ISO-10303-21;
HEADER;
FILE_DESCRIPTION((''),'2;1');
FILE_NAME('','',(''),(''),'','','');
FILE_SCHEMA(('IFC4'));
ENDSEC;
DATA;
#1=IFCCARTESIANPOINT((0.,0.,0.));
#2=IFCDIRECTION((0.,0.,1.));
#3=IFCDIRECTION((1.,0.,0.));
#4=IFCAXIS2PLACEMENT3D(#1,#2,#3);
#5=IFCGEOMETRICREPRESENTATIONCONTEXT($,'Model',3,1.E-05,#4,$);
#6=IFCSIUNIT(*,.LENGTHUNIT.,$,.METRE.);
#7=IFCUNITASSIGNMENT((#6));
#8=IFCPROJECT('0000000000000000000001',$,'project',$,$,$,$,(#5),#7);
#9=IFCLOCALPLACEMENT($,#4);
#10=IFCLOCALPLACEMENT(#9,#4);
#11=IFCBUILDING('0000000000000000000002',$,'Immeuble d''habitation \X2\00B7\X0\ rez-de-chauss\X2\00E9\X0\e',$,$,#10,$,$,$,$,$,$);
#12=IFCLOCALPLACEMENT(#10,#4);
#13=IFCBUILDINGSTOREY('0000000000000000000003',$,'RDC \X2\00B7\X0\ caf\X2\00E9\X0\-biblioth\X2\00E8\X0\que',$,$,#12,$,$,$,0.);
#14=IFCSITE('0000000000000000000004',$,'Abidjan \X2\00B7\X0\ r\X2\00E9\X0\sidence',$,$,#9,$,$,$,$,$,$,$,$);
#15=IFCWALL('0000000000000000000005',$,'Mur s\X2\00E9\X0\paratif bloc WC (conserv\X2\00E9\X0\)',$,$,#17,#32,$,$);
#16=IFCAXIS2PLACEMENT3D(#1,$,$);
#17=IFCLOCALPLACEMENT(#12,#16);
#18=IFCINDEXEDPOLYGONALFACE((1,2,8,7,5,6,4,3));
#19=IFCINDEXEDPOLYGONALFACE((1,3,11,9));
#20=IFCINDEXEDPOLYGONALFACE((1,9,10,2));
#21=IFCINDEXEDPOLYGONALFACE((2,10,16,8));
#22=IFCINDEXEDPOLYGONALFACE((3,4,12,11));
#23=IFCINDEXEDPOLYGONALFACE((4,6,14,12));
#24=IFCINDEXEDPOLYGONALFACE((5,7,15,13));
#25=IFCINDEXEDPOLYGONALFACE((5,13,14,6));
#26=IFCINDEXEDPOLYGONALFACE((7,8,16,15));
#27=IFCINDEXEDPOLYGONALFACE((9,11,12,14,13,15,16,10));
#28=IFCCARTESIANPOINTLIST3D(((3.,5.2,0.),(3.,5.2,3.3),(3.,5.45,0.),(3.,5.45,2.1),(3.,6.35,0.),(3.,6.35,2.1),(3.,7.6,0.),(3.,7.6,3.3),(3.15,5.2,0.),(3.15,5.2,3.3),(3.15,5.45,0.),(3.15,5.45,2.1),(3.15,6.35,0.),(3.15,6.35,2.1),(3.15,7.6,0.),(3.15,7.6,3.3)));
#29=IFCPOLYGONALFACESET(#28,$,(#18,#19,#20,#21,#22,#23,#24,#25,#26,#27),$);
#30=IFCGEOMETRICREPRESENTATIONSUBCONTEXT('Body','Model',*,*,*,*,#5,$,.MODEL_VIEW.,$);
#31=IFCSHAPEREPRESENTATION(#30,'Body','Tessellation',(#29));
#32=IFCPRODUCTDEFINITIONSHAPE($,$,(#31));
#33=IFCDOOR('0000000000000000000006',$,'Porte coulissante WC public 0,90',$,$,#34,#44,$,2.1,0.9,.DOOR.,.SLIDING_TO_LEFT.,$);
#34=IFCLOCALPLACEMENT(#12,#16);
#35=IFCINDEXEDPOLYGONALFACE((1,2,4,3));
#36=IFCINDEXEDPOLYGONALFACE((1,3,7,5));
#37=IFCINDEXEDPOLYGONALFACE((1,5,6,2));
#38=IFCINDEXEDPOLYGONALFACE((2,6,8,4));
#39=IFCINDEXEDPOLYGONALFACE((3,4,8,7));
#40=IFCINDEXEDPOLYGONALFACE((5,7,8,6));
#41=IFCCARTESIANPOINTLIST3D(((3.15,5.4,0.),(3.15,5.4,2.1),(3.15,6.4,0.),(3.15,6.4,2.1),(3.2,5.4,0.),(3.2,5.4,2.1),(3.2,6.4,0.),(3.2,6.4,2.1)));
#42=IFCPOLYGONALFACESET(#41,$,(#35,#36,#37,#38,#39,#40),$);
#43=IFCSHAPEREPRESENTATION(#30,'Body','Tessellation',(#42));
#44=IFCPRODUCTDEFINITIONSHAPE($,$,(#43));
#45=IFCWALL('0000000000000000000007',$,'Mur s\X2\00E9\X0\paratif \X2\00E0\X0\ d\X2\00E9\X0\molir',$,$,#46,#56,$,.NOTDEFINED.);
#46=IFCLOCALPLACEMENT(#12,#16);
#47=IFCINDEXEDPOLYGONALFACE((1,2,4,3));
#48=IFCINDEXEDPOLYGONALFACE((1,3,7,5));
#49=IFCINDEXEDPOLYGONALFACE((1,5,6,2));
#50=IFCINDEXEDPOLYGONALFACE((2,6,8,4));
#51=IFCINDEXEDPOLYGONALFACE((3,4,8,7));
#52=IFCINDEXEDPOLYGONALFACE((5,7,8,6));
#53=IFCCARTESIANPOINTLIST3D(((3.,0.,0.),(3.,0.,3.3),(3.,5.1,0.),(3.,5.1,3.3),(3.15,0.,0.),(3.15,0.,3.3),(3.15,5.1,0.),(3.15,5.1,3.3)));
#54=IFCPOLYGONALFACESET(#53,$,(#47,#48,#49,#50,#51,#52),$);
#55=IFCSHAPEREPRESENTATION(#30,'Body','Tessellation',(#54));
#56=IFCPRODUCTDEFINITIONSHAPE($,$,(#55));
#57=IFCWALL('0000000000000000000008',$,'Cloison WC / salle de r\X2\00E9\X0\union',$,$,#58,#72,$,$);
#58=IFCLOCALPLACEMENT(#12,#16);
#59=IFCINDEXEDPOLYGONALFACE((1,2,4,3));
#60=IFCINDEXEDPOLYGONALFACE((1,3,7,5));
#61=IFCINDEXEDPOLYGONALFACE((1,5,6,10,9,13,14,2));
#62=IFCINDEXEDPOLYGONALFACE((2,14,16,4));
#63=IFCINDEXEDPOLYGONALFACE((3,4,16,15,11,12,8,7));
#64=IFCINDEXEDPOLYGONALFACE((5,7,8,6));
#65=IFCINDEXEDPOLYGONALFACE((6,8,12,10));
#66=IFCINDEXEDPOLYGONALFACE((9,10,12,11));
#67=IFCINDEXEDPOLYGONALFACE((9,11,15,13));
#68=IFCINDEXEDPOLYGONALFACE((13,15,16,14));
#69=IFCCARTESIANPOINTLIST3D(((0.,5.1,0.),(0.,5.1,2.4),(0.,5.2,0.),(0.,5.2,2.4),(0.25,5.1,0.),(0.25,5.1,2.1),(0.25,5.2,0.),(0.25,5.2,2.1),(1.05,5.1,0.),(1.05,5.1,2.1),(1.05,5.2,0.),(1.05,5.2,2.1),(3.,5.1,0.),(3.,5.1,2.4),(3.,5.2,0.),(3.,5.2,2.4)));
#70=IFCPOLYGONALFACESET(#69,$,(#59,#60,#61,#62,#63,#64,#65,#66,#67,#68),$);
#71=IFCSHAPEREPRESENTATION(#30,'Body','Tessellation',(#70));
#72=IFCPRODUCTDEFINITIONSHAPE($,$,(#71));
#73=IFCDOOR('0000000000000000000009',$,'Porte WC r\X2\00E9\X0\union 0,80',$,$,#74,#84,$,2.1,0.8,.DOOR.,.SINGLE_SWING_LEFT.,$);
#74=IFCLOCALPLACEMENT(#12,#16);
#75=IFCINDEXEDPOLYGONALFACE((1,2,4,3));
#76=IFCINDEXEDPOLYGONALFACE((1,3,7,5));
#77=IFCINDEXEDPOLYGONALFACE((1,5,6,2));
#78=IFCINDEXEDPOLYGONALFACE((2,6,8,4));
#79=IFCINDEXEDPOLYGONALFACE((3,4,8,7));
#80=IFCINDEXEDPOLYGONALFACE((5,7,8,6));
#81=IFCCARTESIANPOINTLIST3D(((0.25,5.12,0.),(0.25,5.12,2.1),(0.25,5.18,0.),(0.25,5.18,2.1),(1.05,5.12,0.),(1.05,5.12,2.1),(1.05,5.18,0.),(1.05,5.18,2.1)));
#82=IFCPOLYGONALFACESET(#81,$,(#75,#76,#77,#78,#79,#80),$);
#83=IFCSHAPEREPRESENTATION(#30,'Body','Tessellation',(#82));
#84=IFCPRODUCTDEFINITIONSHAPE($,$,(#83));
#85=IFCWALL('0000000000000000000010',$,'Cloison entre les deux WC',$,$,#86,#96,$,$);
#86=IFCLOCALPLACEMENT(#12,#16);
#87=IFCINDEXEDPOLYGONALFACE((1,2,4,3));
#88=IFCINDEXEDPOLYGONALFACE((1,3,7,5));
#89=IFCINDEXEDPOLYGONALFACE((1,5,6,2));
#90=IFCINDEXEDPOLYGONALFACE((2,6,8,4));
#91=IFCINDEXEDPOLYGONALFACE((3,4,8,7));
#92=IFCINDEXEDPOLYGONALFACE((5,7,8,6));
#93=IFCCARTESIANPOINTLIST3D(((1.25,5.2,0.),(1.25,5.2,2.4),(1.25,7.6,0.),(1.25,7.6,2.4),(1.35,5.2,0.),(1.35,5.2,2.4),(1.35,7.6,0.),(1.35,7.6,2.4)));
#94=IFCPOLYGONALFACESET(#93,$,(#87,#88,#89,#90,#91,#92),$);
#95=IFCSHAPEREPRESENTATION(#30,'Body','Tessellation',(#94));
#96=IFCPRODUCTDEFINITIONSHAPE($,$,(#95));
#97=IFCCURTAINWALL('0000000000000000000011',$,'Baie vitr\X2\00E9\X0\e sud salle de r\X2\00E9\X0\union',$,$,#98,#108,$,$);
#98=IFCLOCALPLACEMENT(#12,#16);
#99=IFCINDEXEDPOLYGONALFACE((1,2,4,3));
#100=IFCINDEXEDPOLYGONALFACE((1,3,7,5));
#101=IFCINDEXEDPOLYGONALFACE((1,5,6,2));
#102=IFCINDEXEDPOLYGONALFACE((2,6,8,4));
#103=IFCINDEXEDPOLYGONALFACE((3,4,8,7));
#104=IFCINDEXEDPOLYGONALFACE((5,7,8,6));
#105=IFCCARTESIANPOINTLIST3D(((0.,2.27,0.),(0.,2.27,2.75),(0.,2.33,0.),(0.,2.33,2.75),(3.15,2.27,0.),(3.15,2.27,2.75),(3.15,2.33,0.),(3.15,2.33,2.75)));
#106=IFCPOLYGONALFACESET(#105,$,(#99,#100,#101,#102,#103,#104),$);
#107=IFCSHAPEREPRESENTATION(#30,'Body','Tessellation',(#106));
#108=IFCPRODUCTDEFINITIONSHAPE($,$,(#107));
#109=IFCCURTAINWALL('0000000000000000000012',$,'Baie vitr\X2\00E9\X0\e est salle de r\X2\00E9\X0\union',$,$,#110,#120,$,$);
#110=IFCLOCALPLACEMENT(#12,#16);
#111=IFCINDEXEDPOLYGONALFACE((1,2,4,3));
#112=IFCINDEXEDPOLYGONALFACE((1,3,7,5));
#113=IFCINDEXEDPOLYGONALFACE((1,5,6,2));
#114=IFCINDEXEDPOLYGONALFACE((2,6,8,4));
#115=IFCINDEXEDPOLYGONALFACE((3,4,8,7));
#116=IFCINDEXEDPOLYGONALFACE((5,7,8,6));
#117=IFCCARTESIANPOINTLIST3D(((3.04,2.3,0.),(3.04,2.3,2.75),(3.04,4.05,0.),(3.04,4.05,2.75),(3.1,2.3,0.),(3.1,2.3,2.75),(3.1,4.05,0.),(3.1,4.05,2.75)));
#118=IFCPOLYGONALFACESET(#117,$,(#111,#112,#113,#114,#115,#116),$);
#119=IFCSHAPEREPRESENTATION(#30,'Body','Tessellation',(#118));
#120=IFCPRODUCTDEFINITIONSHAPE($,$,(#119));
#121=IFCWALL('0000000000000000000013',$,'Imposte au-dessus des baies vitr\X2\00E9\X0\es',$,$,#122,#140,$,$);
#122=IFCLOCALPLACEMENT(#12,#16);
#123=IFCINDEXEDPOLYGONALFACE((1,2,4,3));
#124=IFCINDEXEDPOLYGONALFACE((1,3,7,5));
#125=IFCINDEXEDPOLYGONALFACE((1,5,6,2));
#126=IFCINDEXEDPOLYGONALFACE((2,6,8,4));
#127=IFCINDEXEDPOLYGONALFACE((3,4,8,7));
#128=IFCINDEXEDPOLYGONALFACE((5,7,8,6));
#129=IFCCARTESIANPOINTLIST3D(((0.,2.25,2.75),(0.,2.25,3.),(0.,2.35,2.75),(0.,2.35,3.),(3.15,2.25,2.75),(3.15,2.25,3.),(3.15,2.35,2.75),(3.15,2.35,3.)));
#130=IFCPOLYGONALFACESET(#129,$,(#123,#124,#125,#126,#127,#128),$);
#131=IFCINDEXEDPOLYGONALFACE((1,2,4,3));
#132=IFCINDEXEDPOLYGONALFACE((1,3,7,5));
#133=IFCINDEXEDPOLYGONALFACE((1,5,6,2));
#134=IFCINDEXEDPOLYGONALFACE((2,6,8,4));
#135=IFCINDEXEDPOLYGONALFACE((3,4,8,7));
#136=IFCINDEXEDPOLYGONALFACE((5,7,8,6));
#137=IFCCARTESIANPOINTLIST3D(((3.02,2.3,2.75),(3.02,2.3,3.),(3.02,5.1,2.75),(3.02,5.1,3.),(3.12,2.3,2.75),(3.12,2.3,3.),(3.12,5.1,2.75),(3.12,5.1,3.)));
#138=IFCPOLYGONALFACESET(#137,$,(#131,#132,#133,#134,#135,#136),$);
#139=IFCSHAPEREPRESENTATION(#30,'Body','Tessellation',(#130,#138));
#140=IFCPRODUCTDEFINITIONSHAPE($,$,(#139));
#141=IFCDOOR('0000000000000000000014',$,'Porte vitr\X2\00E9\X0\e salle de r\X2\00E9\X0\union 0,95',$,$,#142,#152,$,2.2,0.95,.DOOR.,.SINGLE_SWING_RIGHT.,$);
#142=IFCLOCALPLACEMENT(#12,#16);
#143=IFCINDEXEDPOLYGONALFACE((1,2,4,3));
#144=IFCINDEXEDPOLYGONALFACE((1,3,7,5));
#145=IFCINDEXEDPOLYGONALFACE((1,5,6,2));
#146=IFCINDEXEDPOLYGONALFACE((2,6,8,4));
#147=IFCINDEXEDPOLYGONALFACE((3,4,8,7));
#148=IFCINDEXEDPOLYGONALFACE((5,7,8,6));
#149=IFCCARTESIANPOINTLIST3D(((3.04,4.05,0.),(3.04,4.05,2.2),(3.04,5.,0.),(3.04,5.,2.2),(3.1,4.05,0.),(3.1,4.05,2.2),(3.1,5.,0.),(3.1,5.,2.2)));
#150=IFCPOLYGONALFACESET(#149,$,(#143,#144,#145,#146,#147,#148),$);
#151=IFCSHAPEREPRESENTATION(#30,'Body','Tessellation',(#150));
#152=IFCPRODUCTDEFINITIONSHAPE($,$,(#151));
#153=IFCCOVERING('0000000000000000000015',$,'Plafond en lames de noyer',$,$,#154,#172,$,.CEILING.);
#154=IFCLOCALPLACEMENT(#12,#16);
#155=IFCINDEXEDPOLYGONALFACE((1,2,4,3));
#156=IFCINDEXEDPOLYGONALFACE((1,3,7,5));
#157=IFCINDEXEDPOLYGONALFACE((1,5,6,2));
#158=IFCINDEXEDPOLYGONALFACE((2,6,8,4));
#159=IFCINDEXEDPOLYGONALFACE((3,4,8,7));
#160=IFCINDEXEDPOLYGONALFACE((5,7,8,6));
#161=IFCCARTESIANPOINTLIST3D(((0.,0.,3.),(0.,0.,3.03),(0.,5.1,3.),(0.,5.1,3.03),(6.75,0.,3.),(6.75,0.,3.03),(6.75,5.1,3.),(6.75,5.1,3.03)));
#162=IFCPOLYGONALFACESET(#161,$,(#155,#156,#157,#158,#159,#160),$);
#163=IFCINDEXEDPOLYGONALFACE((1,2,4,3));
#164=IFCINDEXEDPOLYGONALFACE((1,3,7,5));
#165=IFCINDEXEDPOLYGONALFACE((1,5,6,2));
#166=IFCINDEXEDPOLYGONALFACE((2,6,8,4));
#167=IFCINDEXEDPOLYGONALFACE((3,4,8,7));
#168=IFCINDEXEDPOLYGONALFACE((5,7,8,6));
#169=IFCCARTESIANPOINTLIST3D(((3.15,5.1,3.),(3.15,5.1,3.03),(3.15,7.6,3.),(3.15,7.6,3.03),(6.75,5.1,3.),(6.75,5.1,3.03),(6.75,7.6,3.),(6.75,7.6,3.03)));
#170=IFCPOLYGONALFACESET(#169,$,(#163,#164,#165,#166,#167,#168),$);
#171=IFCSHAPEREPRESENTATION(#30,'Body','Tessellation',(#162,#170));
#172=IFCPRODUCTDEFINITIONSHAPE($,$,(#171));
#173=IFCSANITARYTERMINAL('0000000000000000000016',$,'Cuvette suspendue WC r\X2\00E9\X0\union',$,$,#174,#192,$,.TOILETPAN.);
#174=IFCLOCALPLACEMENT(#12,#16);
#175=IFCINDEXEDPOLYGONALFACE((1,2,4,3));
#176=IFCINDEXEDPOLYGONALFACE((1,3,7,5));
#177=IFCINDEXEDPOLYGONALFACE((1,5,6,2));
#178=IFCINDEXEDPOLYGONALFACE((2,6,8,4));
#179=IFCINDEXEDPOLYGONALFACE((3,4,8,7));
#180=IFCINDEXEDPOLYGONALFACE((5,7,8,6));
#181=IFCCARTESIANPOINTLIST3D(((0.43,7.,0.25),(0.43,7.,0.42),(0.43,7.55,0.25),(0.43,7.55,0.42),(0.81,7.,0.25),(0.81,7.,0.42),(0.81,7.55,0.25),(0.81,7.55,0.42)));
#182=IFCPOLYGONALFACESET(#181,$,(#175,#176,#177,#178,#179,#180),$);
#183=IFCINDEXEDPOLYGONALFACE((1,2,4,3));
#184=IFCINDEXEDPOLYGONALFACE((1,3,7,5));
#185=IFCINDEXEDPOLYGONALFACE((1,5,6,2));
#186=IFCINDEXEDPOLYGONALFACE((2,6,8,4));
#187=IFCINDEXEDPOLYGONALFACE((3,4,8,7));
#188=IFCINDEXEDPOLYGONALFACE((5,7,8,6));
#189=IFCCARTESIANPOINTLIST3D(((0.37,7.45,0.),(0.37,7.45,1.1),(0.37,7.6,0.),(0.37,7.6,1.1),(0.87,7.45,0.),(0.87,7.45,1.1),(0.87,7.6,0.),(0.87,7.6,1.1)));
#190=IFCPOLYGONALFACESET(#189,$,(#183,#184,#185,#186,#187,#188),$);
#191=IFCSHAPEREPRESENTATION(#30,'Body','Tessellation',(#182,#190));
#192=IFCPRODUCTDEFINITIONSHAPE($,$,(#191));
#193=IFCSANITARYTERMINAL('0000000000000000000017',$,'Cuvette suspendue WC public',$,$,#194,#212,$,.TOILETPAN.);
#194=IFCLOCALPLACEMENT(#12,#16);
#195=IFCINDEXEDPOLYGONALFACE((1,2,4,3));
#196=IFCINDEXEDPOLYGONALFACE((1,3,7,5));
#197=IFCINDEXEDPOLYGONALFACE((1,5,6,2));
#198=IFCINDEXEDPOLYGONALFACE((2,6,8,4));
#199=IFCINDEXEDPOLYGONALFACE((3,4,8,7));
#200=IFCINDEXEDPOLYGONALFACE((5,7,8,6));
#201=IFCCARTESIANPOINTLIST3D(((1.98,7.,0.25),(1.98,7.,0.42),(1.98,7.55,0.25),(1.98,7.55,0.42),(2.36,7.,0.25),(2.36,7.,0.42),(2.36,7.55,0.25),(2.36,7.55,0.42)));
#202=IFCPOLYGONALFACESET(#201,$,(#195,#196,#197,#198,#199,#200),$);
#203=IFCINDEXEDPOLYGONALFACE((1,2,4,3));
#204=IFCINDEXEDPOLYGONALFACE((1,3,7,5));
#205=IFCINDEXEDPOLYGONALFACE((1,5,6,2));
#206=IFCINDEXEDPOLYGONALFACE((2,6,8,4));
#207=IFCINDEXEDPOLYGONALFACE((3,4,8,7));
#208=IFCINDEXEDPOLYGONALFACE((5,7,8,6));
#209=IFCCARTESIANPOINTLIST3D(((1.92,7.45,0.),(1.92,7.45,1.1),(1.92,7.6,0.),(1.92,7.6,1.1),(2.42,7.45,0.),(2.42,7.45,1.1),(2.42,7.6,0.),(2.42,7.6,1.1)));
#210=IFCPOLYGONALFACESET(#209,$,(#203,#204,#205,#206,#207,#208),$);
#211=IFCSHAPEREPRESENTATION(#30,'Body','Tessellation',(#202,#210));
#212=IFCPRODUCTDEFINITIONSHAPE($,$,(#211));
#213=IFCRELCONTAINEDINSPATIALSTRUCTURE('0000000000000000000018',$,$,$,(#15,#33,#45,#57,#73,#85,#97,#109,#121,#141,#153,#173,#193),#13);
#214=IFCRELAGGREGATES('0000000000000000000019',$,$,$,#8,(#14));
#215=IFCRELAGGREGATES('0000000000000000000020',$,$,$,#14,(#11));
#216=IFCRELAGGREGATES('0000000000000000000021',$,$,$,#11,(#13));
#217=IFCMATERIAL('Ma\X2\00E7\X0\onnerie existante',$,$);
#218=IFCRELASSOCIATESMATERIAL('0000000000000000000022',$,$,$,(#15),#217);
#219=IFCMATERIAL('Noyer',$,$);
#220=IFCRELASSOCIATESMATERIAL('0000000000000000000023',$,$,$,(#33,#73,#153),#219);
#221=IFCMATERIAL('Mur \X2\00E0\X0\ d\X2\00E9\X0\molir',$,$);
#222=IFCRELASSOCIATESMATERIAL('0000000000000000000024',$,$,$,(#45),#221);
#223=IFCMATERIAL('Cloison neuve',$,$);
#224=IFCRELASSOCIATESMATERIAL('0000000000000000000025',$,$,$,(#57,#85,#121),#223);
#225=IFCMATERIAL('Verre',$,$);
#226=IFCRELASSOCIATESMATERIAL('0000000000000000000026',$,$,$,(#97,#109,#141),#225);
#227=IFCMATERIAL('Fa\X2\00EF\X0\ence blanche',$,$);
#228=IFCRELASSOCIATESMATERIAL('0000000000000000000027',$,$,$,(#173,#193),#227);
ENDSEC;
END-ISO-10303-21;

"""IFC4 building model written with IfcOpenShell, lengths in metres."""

from ifc_helpers import new_model, si_unit, frame, frame_2d, origin, origin_with_axes, place, context, subcontext, project, spatial, rectangle, extrude, material, element, fill, save


model = new_model("IFC4")

# Units and contexts
model_context = context("Model", 3, precision=1e-05, world=origin_with_axes())
body_context = subcontext(model_context, "Body", "Model", "MODEL_VIEW")
ifc_project = project(units=[si_unit("LENGTHUNIT", "METRE")], contexts=[model_context])

# Site, building, storey
site_placement = place(None, origin_with_axes())
site = spatial("IfcSite", under=ifc_project, at=site_placement, Name="Abidjan · résidence")
building_placement = place(site_placement, origin_with_axes())
building = spatial("IfcBuilding", under=site, at=building_placement, Name="Immeuble d'habitation · rez-de-chaussée")
storey_placement = place(building_placement, origin_with_axes())
storey = spatial("IfcBuildingStorey", under=building, at=storey_placement, Name="RDC · café-bibliothèque", Elevation=0.0)

# Shared definitions
ifc_material_1 = material(Name="Cloison neuve")

# Shared definitions
ifc_material_2 = material(Name="Maçonnerie existante")

# Shared definitions
ifc_material_3 = material(Name="Verre")

# Wall, opening, door
wall_1_placement = place(storey_placement, origin_with_axes())
wall_1 = element("IfcWall", 1, at=wall_1_placement, inside=storey, material=ifc_material_2, Name="Mur séparatif bloc WC (conservé)", context=body_context, shape_type="SweptSolid", body=[
    extrude(rectangle(XDim=0.15, YDim=2.4, at=frame_2d((3.075, 6.4))), origin(), (0.0, 0.0, 1.0), 3.3),
])
opening_1_placement = place(wall_1_placement, origin_with_axes())
opening_1 = element("IfcOpeningElement", 2, at=opening_1_placement, cuts=wall_1, context=body_context, shape_type="SweptSolid", body=[
    extrude(rectangle(XDim=0.25, YDim=0.9, at=frame_2d((3.075, 5.9))), origin(), (0.0, 0.0, 1.0), 2.1),
])
ifc_material_4 = material(Name="Noyer")
door_1_placement = place(storey_placement, origin_with_axes())
door_1 = element("IfcDoor", 3, at=door_1_placement, inside=storey, material=ifc_material_4, Name="Porte coulissante WC public 0,90", OperationType="SLIDING_TO_LEFT", OverallHeight=2.1, OverallWidth=0.9, PredefinedType="DOOR", context=body_context, shape_type="SweptSolid", body=[
    extrude(rectangle(XDim=0.05, YDim=1.0, at=frame_2d((3.175, 5.9))), origin(), (0.0, 0.0, 1.0), 2.1),
])
fill(opening_1, door_1)

# Wall
ifc_material_5 = material(Name="Mur à démolir")
wall_2_placement = place(storey_placement, origin_with_axes())
element("IfcWall", 4, at=wall_2_placement, inside=storey, material=ifc_material_5, Name="Mur séparatif à démolir", PredefinedType="NOTDEFINED", context=body_context, shape_type="SweptSolid", body=[
    extrude(rectangle(XDim=0.15, YDim=5.1, at=frame_2d((3.075, 2.55))), origin(), (0.0, 0.0, 1.0), 3.3),
])

# Wall, opening, door
wall_3_placement = place(storey_placement, origin_with_axes())
wall_3 = element("IfcWall", 5, at=wall_3_placement, inside=storey, material=ifc_material_1, Name="Cloison WC / salle de réunion", context=body_context, shape_type="SweptSolid", body=[
    extrude(rectangle(XDim=3.0, YDim=0.1, at=frame_2d((1.5, 5.15))), origin(), (0.0, 0.0, 1.0), 2.4),
])
opening_2_placement = place(wall_3_placement, origin_with_axes())
opening_2 = element("IfcOpeningElement", 6, at=opening_2_placement, cuts=wall_3, context=body_context, shape_type="SweptSolid", body=[
    extrude(rectangle(XDim=0.8, YDim=0.2, at=frame_2d((0.65, 5.15))), origin(), (0.0, 0.0, 1.0), 2.1),
])
door_2_placement = place(storey_placement, origin_with_axes())
door_2 = element("IfcDoor", 7, at=door_2_placement, inside=storey, material=ifc_material_4, Name="Porte WC réunion 0,80", OperationType="SINGLE_SWING_LEFT", OverallHeight=2.1, OverallWidth=0.8, PredefinedType="DOOR", context=body_context, shape_type="SweptSolid", body=[
    extrude(rectangle(XDim=0.8, YDim=0.06, at=frame_2d((0.65, 5.15))), origin(), (0.0, 0.0, 1.0), 2.1),
])
fill(opening_2, door_2)

# Wall
wall_4_placement = place(storey_placement, origin_with_axes())
element("IfcWall", 8, at=wall_4_placement, inside=storey, material=ifc_material_1, Name="Cloison entre les deux WC", context=body_context, shape_type="SweptSolid", body=[
    extrude(rectangle(XDim=0.1, YDim=2.4, at=frame_2d((1.3, 6.4))), origin(), (0.0, 0.0, 1.0), 2.4),
])

# Curtain walls
curtain_wall_1_placement = place(storey_placement, origin_with_axes())
element("IfcCurtainWall", 9, at=curtain_wall_1_placement, inside=storey, material=ifc_material_3, Name="Baie vitrée sud salle de réunion", context=body_context, shape_type="SweptSolid", body=[
    extrude(rectangle(XDim=3.15, YDim=0.06, at=frame_2d((1.575, 2.3))), origin(), (0.0, 0.0, 1.0), 2.75),
])
curtain_wall_2_placement = place(storey_placement, origin_with_axes())
element("IfcCurtainWall", 10, at=curtain_wall_2_placement, inside=storey, material=ifc_material_3, Name="Baie vitrée est salle de réunion", context=body_context, shape_type="SweptSolid", body=[
    extrude(rectangle(XDim=0.06, YDim=1.75, at=frame_2d((3.07, 3.175))), origin(), (0.0, 0.0, 1.0), 2.75),
])

# Wall
wall_5_placement = place(storey_placement, origin_with_axes())
element("IfcWall", 11, at=wall_5_placement, inside=storey, material=ifc_material_1, Name="Imposte au-dessus des baies vitrées", context=body_context, shape_type="SweptSolid", body=[
    extrude(rectangle(XDim=3.15, YDim=0.1, at=frame_2d((1.575, 2.3))), frame((0.0, 0.0, 2.75)), (0.0, 0.0, 1.0), 0.25),
    extrude(rectangle(XDim=0.1, YDim=2.8, at=frame_2d((3.07, 3.7))), frame((0.0, 0.0, 2.75)), (0.0, 0.0, 1.0), 0.25),
])

# Door
door_3_placement = place(storey_placement, origin_with_axes())
element("IfcDoor", 12, at=door_3_placement, inside=storey, material=ifc_material_3, Name="Porte vitrée salle de réunion 0,95", OperationType="SINGLE_SWING_RIGHT", OverallHeight=2.2, OverallWidth=0.95, PredefinedType="DOOR", context=body_context, shape_type="SweptSolid", body=[
    extrude(rectangle(XDim=0.06, YDim=0.95, at=frame_2d((3.07, 4.525))), origin(), (0.0, 0.0, 1.0), 2.2),
])

# Covering
covering_placement = place(storey_placement, origin_with_axes())
element("IfcCovering", 13, at=covering_placement, inside=storey, material=ifc_material_4, Name="Plafond en lames de noyer", PredefinedType="CEILING", context=body_context, shape_type="SweptSolid", body=[
    extrude(rectangle(XDim=6.75, YDim=5.1, at=frame_2d((3.375, 2.55))), frame((0.0, 0.0, 3.0)), (0.0, 0.0, 1.0), 0.03),
    extrude(rectangle(XDim=3.6, YDim=2.5, at=frame_2d((4.95, 6.35))), frame((0.0, 0.0, 3.0)), (0.0, 0.0, 1.0), 0.03),
])

# Sanitary terminals
ifc_material_6 = material(Name="Faïence blanche")
sanitary_terminal_1_placement = place(storey_placement, origin_with_axes())
element("IfcSanitaryTerminal", 14, at=sanitary_terminal_1_placement, inside=storey, material=ifc_material_6, Name="Cuvette suspendue WC réunion", PredefinedType="TOILETPAN", context=body_context, shape_type="SweptSolid", body=[
    extrude(rectangle(XDim=0.38, YDim=0.55, at=frame_2d((0.62, 7.275))), frame((0.0, 0.0, 0.25)), (0.0, 0.0, 1.0), 0.17),
    extrude(rectangle(XDim=0.5, YDim=0.15, at=frame_2d((0.62, 7.525))), origin(), (0.0, 0.0, 1.0), 1.1),
])
sanitary_terminal_2_placement = place(storey_placement, origin_with_axes())
element("IfcSanitaryTerminal", 15, at=sanitary_terminal_2_placement, inside=storey, material=ifc_material_6, Name="Cuvette suspendue WC public", PredefinedType="TOILETPAN", context=body_context, shape_type="SweptSolid", body=[
    extrude(rectangle(XDim=0.38, YDim=0.55, at=frame_2d((2.17, 7.275))), frame((0.0, 0.0, 0.25)), (0.0, 0.0, 1.0), 0.17),
    extrude(rectangle(XDim=0.5, YDim=0.15, at=frame_2d((2.17, 7.525))), origin(), (0.0, 0.0, 1.0), 1.1),
])

save(model, "model.ifc")
